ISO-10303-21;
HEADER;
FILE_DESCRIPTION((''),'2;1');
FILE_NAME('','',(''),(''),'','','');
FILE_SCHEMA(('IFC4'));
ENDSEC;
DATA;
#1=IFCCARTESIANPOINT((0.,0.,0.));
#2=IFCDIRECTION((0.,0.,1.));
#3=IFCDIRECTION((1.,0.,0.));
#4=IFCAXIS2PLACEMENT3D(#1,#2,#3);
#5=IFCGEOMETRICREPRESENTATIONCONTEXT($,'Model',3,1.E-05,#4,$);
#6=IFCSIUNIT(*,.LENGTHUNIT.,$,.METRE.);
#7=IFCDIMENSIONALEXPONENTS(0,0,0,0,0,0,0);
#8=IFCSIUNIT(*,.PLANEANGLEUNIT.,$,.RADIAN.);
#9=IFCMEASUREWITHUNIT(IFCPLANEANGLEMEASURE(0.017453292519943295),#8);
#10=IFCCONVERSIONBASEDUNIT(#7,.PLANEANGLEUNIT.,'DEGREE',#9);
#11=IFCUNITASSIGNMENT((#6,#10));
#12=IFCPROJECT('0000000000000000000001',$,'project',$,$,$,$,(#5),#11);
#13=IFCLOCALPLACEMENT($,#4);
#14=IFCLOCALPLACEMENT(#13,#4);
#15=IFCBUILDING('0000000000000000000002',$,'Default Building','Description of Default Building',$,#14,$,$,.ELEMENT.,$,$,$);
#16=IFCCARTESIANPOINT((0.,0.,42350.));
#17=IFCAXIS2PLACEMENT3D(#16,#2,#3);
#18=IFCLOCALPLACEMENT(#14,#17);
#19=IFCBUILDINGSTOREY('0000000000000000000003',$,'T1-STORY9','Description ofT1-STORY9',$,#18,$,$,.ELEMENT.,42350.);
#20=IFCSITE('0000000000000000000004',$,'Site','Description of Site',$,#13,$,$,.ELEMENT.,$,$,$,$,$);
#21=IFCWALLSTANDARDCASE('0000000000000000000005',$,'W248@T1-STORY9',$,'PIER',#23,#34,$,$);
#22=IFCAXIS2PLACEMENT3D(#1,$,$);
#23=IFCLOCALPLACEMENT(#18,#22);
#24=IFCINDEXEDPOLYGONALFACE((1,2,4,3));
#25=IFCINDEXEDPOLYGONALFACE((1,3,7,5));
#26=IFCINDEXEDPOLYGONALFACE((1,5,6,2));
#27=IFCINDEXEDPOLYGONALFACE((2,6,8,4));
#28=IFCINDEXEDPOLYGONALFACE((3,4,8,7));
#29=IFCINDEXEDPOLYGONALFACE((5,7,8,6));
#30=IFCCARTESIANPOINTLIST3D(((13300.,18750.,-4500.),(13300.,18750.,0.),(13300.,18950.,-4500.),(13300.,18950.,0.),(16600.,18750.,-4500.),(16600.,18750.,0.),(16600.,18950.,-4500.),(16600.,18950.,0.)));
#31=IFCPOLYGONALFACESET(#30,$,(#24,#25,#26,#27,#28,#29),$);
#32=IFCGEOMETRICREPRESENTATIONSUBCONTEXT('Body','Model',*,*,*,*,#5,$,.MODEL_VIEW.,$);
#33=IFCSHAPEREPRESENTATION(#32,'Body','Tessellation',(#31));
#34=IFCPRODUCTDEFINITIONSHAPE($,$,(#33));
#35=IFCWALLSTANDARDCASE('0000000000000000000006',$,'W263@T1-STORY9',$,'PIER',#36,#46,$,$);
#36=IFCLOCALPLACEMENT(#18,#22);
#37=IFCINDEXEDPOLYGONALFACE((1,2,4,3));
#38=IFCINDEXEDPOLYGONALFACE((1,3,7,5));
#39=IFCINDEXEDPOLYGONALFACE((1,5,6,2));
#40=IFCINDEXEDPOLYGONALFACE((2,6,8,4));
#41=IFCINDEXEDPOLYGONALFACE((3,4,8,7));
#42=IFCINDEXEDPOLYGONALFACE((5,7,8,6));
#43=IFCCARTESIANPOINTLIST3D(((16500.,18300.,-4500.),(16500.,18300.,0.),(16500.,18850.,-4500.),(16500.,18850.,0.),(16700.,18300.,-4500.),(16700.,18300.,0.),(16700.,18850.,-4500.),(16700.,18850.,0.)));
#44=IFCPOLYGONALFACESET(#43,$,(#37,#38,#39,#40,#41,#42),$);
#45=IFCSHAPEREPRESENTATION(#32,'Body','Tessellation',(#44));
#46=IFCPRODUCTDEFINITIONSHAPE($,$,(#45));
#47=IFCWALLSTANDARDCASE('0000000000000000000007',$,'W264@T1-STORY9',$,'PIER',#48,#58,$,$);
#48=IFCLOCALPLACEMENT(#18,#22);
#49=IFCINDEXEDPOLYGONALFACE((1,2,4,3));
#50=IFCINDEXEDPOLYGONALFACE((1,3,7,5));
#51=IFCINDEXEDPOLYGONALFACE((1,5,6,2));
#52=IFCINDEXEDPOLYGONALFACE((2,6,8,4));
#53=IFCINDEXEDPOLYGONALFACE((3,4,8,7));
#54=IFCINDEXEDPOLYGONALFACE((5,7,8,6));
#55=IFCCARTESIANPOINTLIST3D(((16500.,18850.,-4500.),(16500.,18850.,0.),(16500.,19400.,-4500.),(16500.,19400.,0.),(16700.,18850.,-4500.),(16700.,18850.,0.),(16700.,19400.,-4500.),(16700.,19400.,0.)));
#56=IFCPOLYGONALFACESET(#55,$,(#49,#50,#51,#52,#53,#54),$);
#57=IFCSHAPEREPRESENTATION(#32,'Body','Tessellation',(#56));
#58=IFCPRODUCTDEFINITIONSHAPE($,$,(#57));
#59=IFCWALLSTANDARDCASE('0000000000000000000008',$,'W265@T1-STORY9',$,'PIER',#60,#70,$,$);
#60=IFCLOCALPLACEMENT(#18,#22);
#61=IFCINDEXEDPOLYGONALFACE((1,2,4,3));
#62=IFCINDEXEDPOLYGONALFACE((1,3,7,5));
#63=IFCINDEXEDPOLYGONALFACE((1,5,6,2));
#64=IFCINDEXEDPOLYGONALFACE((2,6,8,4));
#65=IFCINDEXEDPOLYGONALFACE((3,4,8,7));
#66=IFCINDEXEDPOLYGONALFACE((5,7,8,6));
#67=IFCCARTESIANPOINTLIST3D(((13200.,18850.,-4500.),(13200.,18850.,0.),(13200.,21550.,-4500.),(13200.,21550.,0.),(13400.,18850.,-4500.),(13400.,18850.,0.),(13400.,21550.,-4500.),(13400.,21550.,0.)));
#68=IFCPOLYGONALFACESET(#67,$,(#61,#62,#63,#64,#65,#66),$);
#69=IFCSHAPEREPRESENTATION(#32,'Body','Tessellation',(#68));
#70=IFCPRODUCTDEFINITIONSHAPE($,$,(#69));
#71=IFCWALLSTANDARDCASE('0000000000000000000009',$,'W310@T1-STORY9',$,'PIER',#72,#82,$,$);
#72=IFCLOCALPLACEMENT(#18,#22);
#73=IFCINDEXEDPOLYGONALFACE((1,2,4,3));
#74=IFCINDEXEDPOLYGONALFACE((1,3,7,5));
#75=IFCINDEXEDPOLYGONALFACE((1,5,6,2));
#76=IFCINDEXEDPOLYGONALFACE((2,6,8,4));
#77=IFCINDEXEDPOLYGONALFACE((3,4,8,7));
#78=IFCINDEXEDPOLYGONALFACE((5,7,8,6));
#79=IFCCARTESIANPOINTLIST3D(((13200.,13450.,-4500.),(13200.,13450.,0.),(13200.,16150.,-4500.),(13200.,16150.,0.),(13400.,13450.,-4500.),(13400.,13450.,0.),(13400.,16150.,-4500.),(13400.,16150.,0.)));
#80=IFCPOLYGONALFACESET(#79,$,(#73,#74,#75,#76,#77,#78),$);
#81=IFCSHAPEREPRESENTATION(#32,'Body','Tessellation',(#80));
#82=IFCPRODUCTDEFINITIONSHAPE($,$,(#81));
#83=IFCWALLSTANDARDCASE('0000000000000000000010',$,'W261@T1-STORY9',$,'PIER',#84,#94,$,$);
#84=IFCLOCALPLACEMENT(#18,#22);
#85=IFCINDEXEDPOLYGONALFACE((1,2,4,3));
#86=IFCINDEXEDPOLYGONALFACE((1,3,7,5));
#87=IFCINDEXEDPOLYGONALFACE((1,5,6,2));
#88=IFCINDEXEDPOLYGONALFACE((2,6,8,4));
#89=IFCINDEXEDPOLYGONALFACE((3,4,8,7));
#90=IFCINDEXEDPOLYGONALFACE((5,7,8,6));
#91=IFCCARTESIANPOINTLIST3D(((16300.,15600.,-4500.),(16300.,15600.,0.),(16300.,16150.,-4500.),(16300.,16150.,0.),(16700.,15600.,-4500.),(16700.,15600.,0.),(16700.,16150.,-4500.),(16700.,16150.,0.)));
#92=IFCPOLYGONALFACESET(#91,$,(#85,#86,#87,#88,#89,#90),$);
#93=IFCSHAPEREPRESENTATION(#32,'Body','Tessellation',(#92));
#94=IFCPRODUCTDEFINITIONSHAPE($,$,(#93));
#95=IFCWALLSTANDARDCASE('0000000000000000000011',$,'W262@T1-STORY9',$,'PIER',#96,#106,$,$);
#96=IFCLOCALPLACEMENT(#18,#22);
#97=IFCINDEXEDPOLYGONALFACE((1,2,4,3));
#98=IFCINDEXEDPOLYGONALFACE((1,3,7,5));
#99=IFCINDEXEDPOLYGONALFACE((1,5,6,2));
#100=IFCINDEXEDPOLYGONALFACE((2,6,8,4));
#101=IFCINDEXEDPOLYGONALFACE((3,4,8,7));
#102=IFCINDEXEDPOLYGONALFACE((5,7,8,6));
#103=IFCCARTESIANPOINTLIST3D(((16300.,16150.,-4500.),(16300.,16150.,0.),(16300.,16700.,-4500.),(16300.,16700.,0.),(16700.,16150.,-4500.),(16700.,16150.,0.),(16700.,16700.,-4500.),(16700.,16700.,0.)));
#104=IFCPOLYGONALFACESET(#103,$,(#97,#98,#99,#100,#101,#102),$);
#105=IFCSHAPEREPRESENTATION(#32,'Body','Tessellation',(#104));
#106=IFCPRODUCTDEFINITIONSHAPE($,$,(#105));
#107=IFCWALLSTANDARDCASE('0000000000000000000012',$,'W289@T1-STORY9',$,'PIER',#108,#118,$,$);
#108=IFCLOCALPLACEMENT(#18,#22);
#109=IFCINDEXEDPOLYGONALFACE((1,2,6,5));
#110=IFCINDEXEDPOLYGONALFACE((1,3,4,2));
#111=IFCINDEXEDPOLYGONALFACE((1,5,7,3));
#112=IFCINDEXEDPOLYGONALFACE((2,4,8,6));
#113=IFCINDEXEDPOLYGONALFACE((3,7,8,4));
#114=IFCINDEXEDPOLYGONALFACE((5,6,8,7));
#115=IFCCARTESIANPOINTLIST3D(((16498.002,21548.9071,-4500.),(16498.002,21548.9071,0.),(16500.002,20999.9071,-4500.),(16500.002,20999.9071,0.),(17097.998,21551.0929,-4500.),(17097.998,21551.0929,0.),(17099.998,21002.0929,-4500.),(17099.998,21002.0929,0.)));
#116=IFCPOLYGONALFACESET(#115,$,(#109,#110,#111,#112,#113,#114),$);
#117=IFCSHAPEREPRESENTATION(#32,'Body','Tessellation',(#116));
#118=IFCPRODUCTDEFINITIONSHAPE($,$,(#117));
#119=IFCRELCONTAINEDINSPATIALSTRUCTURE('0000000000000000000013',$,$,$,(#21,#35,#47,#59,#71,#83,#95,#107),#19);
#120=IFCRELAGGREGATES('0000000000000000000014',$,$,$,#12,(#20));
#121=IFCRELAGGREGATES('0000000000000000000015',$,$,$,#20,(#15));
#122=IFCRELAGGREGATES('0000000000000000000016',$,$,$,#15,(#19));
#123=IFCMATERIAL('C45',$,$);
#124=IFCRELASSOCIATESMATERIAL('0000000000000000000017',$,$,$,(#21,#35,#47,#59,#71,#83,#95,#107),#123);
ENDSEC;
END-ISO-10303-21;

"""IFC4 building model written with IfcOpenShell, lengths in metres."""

from ifc_helpers import new_model, entity, si_unit, converted_unit, frame, origin_with_axes, place, context, subcontext, project, spatial, indexed_curve, outline, extrude, material, element, save


model = new_model("IFC4")

# Units and contexts
model_context = context("Model", 3, precision=1e-05, world=origin_with_axes())
body_context = subcontext(model_context, "Body", "Model", "MODEL_VIEW")
ifc_project = project(units=[si_unit("LENGTHUNIT", "METRE"), converted_unit("PLANEANGLEUNIT", "DEGREE", entity("IfcPlaneAngleMeasure", 0.017453292519943295), si_unit("PLANEANGLEUNIT", "RADIAN"), dimensions=[0, 0, 0, 0, 0, 0, 0])], contexts=[model_context])

# Site, building, storey
site_placement = place(None, origin_with_axes())
site = spatial("IfcSite", under=ifc_project, at=site_placement, Name="Site", Description="Description of Site", CompositionType="ELEMENT")
building_placement = place(site_placement, origin_with_axes())
building = spatial("IfcBuilding", under=site, at=building_placement, Name="Default Building", Description="Description of Default Building", CompositionType="ELEMENT")
storey_placement = place(building_placement, frame((0.0, 0.0, 42350.0), z_axis=(0.0, 0.0, 1.0), x_axis=(1.0, 0.0, 0.0)))
storey = spatial("IfcBuildingStorey", under=building, at=storey_placement, Name="T1-STORY9", Description="Description ofT1-STORY9", CompositionType="ELEMENT", Elevation=42350.0)

# Shared definitions
ifc_material_1 = material(Name="C45")

# Walls
wall_1_placement = place(storey_placement, frame((13300.0, 18850.0, -4500.0), z_axis=(0.0, 0.0, 1.0), x_axis=(1.0, 0.0, 0.0)))
element("IfcWallStandardCase", 1, at=wall_1_placement, inside=storey, material=ifc_material_1, Name="W248@T1-STORY9", ObjectType="PIER", context=body_context, shape_type="SweptSolid", body=[
    extrude(outline(indexed_curve([(0.0, -100.0), (0.0, 100.0), (3300.0, 100.0), (3300.0, -100.0), (0.0, -100.0)], self_intersect=False)), origin_with_axes(), (0.0, 0.0, 1.0), 4500.0),
])
for number, where, z_axis, x_axis, name in (
    (2, (16600.0, 18300.0, -4500.0), (0.0, 0.0, 1.0), (0.0, 1.0, 0.0), "W263@T1-STORY9"),
    (3, (16600.0, 18850.0, -4500.0), (0.0, 0.0, 1.0), (0.0, 1.0, 0.0), "W264@T1-STORY9"),
):
    element("IfcWallStandardCase", number, at=place(storey_placement, frame(where, z_axis=z_axis, x_axis=x_axis)), inside=storey, material=ifc_material_1, Name=name, ObjectType="PIER", context=body_context, shape_type="SweptSolid", body=[
        extrude(outline(indexed_curve([(0.0, -100.0), (0.0, 100.0), (550.0, 100.0), (550.0, -100.0), (0.0, -100.0)], self_intersect=False)), origin_with_axes(), (0.0, 0.0, 1.0), 4500.0),
    ])
for number, where, z_axis, x_axis, name in (
    (4, (13300.0, 18850.0, -4500.0), (0.0, 0.0, 1.0), (0.0, 1.0, 0.0), "W265@T1-STORY9"),
    (5, (13300.0, 13450.0, -4500.0), (0.0, 0.0, 1.0), (0.0, 1.0, 0.0), "W310@T1-STORY9"),
):
    element("IfcWallStandardCase", number, at=place(storey_placement, frame(where, z_axis=z_axis, x_axis=x_axis)), inside=storey, material=ifc_material_1, Name=name, ObjectType="PIER", context=body_context, shape_type="SweptSolid", body=[
        extrude(outline(indexed_curve([(0.0, -100.0), (0.0, 100.0), (2700.0, 100.0), (2700.0, -100.0), (0.0, -100.0)], self_intersect=False)), origin_with_axes(), (0.0, 0.0, 1.0), 4500.0),
    ])
for number, where, z_axis, x_axis, name in (
    (6, (16500.0, 15600.0, -4500.0), (0.0, 0.0, 1.0), (0.0, 1.0, 0.0), "W261@T1-STORY9"),
    (7, (16500.0, 16150.0, -4500.0), (0.0, 0.0, 1.0), (0.0, 1.0, 0.0), "W262@T1-STORY9"),
):
    element("IfcWallStandardCase", number, at=place(storey_placement, frame(where, z_axis=z_axis, x_axis=x_axis)), inside=storey, material=ifc_material_1, Name=name, ObjectType="PIER", context=body_context, shape_type="SweptSolid", body=[
        extrude(outline(indexed_curve([(0.0, -200.0), (0.0, 200.0), (550.0, 200.0), (550.0, -200.0), (0.0, -200.0)], self_intersect=False)), origin_with_axes(), (0.0, 0.0, 1.0), 4500.0),
    ])
wall_2_placement = place(storey_placement, frame((16800.0, 21001.0, -4500.0), z_axis=(0.0, 0.0, 1.0), x_axis=(-0.003643, 0.999993, 0.0)))
element("IfcWallStandardCase", 8, at=wall_2_placement, inside=storey, material=ifc_material_1, Name="W289@T1-STORY9", ObjectType="PIER", context=body_context, shape_type="SweptSolid", body=[
    extrude(outline(indexed_curve([(0.0, -300.0), (0.0, 300.0), (549.0036, 300.0), (549.0036, -300.0), (0.0, -300.0)], self_intersect=False)), origin_with_axes(), (0.0, 0.0, 1.0), 4500.0),
])

save(model, "model.ifc")
